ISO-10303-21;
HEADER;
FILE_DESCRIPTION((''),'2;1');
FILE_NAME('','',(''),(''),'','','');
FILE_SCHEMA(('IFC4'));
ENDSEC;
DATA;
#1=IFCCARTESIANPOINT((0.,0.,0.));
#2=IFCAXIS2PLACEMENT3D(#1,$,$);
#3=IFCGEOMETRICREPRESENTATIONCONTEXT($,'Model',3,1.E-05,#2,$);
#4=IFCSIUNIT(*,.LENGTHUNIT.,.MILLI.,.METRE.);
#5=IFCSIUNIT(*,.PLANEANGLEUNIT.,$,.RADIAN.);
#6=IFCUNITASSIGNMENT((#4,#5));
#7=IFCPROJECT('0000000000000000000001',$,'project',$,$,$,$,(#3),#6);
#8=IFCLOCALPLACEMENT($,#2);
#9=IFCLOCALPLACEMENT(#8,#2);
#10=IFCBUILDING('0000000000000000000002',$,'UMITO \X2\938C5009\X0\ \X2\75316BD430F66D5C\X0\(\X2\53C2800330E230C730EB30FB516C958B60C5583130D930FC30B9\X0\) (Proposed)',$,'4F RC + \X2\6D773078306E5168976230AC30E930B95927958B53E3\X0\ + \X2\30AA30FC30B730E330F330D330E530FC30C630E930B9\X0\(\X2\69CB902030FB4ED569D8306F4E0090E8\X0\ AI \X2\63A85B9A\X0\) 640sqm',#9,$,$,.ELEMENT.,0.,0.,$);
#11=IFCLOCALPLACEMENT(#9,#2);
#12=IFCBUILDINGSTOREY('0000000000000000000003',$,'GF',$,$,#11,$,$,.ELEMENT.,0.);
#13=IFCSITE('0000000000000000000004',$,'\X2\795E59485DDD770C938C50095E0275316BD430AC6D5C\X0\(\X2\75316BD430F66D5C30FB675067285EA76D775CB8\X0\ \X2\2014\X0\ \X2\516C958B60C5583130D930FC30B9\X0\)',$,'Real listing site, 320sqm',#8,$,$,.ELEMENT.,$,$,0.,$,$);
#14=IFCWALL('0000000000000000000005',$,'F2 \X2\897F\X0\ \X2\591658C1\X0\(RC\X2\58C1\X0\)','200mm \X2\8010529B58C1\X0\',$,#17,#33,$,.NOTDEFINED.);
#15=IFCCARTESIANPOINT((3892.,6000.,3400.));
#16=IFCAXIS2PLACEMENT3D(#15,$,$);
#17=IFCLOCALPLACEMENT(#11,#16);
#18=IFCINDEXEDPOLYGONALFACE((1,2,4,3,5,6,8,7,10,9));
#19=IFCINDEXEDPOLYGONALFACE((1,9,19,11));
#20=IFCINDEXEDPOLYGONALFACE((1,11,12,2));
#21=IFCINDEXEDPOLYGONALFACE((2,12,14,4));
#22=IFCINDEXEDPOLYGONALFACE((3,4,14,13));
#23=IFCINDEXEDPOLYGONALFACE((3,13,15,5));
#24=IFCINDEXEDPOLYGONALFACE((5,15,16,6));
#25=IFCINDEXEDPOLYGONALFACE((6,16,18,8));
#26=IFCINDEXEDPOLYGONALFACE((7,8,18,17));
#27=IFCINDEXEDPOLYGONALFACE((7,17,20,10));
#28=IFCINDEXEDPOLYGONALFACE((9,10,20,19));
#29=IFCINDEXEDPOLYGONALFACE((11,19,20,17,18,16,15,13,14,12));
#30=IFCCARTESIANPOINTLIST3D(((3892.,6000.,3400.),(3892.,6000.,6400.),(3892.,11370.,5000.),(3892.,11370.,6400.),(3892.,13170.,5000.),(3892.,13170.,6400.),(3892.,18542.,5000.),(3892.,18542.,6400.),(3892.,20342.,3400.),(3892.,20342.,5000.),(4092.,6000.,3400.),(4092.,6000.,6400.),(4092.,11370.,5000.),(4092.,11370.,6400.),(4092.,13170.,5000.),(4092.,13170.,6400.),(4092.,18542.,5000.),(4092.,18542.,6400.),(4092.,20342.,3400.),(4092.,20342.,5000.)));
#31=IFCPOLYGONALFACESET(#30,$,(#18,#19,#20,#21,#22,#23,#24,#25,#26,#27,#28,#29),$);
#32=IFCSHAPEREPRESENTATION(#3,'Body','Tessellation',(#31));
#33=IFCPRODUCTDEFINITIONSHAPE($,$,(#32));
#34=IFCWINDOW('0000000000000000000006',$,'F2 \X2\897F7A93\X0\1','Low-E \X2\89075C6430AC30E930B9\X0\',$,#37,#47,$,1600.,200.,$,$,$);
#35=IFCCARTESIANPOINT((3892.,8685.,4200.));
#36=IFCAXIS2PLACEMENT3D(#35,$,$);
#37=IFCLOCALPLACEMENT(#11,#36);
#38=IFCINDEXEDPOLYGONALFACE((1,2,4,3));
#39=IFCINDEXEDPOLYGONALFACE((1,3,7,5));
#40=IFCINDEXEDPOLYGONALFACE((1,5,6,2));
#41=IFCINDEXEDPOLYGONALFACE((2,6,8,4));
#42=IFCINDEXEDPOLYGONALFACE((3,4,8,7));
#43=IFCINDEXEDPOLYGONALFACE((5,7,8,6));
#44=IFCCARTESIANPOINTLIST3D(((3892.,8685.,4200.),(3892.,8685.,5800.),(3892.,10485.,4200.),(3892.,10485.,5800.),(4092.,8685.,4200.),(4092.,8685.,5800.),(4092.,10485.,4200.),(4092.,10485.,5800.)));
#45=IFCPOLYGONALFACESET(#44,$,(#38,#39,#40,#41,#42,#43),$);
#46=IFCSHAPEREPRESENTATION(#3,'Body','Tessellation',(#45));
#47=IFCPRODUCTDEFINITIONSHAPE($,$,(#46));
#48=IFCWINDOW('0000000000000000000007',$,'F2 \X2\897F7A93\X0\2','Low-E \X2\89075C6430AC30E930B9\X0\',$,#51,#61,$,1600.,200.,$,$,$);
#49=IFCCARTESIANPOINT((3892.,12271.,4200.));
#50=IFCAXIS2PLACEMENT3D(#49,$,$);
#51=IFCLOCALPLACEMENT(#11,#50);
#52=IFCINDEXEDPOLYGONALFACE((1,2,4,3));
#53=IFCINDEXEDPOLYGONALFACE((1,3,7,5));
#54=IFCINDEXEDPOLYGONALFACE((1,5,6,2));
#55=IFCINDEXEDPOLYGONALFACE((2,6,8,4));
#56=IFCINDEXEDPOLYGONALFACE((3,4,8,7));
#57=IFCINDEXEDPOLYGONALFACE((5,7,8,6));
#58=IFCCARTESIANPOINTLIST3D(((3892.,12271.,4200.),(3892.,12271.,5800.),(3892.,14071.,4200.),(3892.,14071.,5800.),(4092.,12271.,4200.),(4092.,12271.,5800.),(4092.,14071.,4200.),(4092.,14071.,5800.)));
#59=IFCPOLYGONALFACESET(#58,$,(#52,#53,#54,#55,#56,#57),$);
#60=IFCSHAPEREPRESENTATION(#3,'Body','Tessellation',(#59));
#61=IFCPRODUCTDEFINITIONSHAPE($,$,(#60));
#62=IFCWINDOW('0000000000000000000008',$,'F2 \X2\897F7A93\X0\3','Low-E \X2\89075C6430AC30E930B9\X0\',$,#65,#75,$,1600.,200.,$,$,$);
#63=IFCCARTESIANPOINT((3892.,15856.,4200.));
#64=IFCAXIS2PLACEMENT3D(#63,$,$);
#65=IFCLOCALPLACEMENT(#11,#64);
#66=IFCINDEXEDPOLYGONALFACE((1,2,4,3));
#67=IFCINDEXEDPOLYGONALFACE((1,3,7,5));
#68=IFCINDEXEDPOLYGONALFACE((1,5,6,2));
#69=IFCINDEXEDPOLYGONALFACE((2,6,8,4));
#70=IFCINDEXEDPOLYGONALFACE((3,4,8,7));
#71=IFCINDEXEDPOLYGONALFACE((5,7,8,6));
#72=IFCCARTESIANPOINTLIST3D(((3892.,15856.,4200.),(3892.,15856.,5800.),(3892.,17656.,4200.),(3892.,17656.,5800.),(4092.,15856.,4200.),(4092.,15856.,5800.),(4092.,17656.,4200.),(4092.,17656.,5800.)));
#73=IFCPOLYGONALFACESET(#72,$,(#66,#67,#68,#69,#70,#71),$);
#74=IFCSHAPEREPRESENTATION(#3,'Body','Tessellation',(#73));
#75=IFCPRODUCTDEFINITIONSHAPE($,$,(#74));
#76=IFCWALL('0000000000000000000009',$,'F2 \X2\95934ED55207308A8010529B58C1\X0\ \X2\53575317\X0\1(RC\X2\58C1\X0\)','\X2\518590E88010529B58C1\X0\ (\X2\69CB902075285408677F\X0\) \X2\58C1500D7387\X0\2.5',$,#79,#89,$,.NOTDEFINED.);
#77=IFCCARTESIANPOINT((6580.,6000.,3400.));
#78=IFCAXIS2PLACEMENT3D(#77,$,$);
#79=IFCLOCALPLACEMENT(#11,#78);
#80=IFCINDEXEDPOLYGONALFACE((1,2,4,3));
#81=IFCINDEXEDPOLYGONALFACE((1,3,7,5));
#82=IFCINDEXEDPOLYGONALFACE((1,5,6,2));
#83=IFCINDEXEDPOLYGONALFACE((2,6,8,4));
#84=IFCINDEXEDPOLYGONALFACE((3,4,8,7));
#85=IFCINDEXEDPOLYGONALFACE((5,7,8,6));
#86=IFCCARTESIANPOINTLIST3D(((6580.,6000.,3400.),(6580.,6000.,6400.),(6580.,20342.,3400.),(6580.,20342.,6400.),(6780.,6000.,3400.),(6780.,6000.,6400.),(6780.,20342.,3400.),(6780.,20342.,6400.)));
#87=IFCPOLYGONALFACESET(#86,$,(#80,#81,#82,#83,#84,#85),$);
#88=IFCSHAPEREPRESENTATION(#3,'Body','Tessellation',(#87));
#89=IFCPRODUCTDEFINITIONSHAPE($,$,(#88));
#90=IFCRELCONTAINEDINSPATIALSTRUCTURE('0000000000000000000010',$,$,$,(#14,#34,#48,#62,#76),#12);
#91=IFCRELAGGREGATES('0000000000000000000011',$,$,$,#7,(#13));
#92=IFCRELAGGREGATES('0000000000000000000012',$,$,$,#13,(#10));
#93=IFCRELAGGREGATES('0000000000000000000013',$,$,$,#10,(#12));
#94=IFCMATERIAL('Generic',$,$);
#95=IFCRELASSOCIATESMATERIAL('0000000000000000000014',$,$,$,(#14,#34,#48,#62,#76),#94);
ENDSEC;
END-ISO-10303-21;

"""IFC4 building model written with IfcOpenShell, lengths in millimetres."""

from ifc_helpers import new_model, si_unit, frame, frame_2d, origin, place, context, project, spatial, rectangle, extrude, material, element, fill, save


model = new_model("IFC4")

# Units and contexts
model_context = context("Model", 3, precision=1e-05, world=origin())
ifc_project = project(units=[si_unit("LENGTHUNIT", "METRE", prefix="MILLI"), si_unit("PLANEANGLEUNIT", "RADIAN")], contexts=[model_context])

# Site, building, storey
site_placement = place(None, origin())
site = spatial("IfcSite", under=ifc_project, at=site_placement, Name="神奈川県鎌倉市由比ガ浜(由比ヶ浜・材木座海岸 — 公開情報ベース)", ObjectType="Real listing site, 320sqm", CompositionType="ELEMENT", RefElevation=0.0)
building_placement = place(site_placement, origin())
building = spatial("IfcBuilding", under=site, at=building_placement, Name="UMITO 鎌倉 由比ヶ浜(参考モデル・公開情報ベース) (Proposed)", ObjectType="4F RC + 海への全面ガラス大開口 + オーシャンビューテラス(構造・仕様は一部 AI 推定) 640sqm", CompositionType="ELEMENT", ElevationOfRefHeight=0.0, ElevationOfTerrain=0.0)
storey_placement = place(building_placement, origin())
storey = spatial("IfcBuildingStorey", under=building, at=storey_placement, Name="GF", CompositionType="ELEMENT", Elevation=0.0)

# Shared definitions
ifc_material = material(Name="Generic")

# Wall, openings, windows
wall_1_placement = place(storey_placement, frame((3892.0, 6000.0, 3400.0)))
wall_1 = element("IfcWall", 1, at=wall_1_placement, inside=storey, material=ifc_material, Name="F2 西 外壁(RC壁)", Description="200mm 耐力壁", PredefinedType="NOTDEFINED", context=model_context, shape_type="SweptSolid", body=[
    extrude(rectangle(XDim=200.0, YDim=14342.0, at=frame_2d((100.0, 7171.0))), frame((3892.0, 6000.0, 3400.0)), (0.0, 0.0, 1.0), 3000.0),
])
opening_1_placement = place(storey_placement, frame((3892.0, 8685.0, 4200.0)))
opening_1 = element("IfcOpeningElement", 2, at=opening_1_placement, cuts=wall_1, PredefinedType="NOTDEFINED", context=model_context, shape_type="SweptSolid", body=[
    extrude(rectangle(XDim=200.0, YDim=1800.0, at=frame_2d((100.0, 900.0))), frame((3892.0, 8685.0, 4200.0)), (0.0, 0.0, 1.0), 1600.0),
])
opening_2_placement = place(storey_placement, frame((3892.0, 12271.0, 4200.0)))
opening_2 = element("IfcOpeningElement", 3, at=opening_2_placement, cuts=wall_1, PredefinedType="NOTDEFINED", context=model_context, shape_type="SweptSolid", body=[
    extrude(rectangle(XDim=200.0, YDim=1800.0, at=frame_2d((100.0, 900.0))), frame((3892.0, 12271.0, 4200.0)), (0.0, 0.0, 1.0), 1600.0),
])
opening_3_placement = place(storey_placement, frame((3892.0, 15856.0, 4200.0)))
opening_3 = element("IfcOpeningElement", 4, at=opening_3_placement, cuts=wall_1, PredefinedType="NOTDEFINED", context=model_context, shape_type="SweptSolid", body=[
    extrude(rectangle(XDim=200.0, YDim=1800.0, at=frame_2d((100.0, 900.0))), frame((3892.0, 15856.0, 4200.0)), (0.0, 0.0, 1.0), 1600.0),
])
window_1_placement = place(storey_placement, frame((3892.0, 8685.0, 4200.0)))
window_1 = element("IfcWindow", 5, at=window_1_placement, inside=storey, material=ifc_material, Name="F2 西窓1", Description="Low-E 複層ガラス", OverallHeight=1600.0, OverallWidth=200.0, context=model_context, shape_type="SweptSolid", body=[
    extrude(rectangle(XDim=200.0, YDim=1800.0, at=frame_2d((100.0, 900.0))), frame((3892.0, 8685.0, 4200.0)), (0.0, 0.0, 1.0), 1600.0),
])
fill(opening_1, window_1)
window_2_placement = place(storey_placement, frame((3892.0, 12271.0, 4200.0)))
window_2 = element("IfcWindow", 6, at=window_2_placement, inside=storey, material=ifc_material, Name="F2 西窓2", Description="Low-E 複層ガラス", OverallHeight=1600.0, OverallWidth=200.0, context=model_context, shape_type="SweptSolid", body=[
    extrude(rectangle(XDim=200.0, YDim=1800.0, at=frame_2d((100.0, 900.0))), frame((3892.0, 12271.0, 4200.0)), (0.0, 0.0, 1.0), 1600.0),
])
fill(opening_2, window_2)
window_3_placement = place(storey_placement, frame((3892.0, 15856.0, 4200.0)))
window_3 = element("IfcWindow", 7, at=window_3_placement, inside=storey, material=ifc_material, Name="F2 西窓3", Description="Low-E 複層ガラス", OverallHeight=1600.0, OverallWidth=200.0, context=model_context, shape_type="SweptSolid", body=[
    extrude(rectangle(XDim=200.0, YDim=1800.0, at=frame_2d((100.0, 900.0))), frame((3892.0, 15856.0, 4200.0)), (0.0, 0.0, 1.0), 1600.0),
])
fill(opening_3, window_3)

# Wall
wall_2_placement = place(storey_placement, frame((6580.0, 6000.0, 3400.0)))
element("IfcWall", 8, at=wall_2_placement, inside=storey, material=ifc_material, Name="F2 間仕切り耐力壁 南北1(RC壁)", Description="内部耐力壁 (構造用合板) 壁倍率2.5", PredefinedType="NOTDEFINED", context=model_context, shape_type="SweptSolid", body=[
    extrude(rectangle(XDim=200.0, YDim=14342.0, at=frame_2d((100.0, 7171.0))), frame((6580.0, 6000.0, 3400.0)), (0.0, 0.0, 1.0), 3000.0),
])

save(model, "model.ifc")
